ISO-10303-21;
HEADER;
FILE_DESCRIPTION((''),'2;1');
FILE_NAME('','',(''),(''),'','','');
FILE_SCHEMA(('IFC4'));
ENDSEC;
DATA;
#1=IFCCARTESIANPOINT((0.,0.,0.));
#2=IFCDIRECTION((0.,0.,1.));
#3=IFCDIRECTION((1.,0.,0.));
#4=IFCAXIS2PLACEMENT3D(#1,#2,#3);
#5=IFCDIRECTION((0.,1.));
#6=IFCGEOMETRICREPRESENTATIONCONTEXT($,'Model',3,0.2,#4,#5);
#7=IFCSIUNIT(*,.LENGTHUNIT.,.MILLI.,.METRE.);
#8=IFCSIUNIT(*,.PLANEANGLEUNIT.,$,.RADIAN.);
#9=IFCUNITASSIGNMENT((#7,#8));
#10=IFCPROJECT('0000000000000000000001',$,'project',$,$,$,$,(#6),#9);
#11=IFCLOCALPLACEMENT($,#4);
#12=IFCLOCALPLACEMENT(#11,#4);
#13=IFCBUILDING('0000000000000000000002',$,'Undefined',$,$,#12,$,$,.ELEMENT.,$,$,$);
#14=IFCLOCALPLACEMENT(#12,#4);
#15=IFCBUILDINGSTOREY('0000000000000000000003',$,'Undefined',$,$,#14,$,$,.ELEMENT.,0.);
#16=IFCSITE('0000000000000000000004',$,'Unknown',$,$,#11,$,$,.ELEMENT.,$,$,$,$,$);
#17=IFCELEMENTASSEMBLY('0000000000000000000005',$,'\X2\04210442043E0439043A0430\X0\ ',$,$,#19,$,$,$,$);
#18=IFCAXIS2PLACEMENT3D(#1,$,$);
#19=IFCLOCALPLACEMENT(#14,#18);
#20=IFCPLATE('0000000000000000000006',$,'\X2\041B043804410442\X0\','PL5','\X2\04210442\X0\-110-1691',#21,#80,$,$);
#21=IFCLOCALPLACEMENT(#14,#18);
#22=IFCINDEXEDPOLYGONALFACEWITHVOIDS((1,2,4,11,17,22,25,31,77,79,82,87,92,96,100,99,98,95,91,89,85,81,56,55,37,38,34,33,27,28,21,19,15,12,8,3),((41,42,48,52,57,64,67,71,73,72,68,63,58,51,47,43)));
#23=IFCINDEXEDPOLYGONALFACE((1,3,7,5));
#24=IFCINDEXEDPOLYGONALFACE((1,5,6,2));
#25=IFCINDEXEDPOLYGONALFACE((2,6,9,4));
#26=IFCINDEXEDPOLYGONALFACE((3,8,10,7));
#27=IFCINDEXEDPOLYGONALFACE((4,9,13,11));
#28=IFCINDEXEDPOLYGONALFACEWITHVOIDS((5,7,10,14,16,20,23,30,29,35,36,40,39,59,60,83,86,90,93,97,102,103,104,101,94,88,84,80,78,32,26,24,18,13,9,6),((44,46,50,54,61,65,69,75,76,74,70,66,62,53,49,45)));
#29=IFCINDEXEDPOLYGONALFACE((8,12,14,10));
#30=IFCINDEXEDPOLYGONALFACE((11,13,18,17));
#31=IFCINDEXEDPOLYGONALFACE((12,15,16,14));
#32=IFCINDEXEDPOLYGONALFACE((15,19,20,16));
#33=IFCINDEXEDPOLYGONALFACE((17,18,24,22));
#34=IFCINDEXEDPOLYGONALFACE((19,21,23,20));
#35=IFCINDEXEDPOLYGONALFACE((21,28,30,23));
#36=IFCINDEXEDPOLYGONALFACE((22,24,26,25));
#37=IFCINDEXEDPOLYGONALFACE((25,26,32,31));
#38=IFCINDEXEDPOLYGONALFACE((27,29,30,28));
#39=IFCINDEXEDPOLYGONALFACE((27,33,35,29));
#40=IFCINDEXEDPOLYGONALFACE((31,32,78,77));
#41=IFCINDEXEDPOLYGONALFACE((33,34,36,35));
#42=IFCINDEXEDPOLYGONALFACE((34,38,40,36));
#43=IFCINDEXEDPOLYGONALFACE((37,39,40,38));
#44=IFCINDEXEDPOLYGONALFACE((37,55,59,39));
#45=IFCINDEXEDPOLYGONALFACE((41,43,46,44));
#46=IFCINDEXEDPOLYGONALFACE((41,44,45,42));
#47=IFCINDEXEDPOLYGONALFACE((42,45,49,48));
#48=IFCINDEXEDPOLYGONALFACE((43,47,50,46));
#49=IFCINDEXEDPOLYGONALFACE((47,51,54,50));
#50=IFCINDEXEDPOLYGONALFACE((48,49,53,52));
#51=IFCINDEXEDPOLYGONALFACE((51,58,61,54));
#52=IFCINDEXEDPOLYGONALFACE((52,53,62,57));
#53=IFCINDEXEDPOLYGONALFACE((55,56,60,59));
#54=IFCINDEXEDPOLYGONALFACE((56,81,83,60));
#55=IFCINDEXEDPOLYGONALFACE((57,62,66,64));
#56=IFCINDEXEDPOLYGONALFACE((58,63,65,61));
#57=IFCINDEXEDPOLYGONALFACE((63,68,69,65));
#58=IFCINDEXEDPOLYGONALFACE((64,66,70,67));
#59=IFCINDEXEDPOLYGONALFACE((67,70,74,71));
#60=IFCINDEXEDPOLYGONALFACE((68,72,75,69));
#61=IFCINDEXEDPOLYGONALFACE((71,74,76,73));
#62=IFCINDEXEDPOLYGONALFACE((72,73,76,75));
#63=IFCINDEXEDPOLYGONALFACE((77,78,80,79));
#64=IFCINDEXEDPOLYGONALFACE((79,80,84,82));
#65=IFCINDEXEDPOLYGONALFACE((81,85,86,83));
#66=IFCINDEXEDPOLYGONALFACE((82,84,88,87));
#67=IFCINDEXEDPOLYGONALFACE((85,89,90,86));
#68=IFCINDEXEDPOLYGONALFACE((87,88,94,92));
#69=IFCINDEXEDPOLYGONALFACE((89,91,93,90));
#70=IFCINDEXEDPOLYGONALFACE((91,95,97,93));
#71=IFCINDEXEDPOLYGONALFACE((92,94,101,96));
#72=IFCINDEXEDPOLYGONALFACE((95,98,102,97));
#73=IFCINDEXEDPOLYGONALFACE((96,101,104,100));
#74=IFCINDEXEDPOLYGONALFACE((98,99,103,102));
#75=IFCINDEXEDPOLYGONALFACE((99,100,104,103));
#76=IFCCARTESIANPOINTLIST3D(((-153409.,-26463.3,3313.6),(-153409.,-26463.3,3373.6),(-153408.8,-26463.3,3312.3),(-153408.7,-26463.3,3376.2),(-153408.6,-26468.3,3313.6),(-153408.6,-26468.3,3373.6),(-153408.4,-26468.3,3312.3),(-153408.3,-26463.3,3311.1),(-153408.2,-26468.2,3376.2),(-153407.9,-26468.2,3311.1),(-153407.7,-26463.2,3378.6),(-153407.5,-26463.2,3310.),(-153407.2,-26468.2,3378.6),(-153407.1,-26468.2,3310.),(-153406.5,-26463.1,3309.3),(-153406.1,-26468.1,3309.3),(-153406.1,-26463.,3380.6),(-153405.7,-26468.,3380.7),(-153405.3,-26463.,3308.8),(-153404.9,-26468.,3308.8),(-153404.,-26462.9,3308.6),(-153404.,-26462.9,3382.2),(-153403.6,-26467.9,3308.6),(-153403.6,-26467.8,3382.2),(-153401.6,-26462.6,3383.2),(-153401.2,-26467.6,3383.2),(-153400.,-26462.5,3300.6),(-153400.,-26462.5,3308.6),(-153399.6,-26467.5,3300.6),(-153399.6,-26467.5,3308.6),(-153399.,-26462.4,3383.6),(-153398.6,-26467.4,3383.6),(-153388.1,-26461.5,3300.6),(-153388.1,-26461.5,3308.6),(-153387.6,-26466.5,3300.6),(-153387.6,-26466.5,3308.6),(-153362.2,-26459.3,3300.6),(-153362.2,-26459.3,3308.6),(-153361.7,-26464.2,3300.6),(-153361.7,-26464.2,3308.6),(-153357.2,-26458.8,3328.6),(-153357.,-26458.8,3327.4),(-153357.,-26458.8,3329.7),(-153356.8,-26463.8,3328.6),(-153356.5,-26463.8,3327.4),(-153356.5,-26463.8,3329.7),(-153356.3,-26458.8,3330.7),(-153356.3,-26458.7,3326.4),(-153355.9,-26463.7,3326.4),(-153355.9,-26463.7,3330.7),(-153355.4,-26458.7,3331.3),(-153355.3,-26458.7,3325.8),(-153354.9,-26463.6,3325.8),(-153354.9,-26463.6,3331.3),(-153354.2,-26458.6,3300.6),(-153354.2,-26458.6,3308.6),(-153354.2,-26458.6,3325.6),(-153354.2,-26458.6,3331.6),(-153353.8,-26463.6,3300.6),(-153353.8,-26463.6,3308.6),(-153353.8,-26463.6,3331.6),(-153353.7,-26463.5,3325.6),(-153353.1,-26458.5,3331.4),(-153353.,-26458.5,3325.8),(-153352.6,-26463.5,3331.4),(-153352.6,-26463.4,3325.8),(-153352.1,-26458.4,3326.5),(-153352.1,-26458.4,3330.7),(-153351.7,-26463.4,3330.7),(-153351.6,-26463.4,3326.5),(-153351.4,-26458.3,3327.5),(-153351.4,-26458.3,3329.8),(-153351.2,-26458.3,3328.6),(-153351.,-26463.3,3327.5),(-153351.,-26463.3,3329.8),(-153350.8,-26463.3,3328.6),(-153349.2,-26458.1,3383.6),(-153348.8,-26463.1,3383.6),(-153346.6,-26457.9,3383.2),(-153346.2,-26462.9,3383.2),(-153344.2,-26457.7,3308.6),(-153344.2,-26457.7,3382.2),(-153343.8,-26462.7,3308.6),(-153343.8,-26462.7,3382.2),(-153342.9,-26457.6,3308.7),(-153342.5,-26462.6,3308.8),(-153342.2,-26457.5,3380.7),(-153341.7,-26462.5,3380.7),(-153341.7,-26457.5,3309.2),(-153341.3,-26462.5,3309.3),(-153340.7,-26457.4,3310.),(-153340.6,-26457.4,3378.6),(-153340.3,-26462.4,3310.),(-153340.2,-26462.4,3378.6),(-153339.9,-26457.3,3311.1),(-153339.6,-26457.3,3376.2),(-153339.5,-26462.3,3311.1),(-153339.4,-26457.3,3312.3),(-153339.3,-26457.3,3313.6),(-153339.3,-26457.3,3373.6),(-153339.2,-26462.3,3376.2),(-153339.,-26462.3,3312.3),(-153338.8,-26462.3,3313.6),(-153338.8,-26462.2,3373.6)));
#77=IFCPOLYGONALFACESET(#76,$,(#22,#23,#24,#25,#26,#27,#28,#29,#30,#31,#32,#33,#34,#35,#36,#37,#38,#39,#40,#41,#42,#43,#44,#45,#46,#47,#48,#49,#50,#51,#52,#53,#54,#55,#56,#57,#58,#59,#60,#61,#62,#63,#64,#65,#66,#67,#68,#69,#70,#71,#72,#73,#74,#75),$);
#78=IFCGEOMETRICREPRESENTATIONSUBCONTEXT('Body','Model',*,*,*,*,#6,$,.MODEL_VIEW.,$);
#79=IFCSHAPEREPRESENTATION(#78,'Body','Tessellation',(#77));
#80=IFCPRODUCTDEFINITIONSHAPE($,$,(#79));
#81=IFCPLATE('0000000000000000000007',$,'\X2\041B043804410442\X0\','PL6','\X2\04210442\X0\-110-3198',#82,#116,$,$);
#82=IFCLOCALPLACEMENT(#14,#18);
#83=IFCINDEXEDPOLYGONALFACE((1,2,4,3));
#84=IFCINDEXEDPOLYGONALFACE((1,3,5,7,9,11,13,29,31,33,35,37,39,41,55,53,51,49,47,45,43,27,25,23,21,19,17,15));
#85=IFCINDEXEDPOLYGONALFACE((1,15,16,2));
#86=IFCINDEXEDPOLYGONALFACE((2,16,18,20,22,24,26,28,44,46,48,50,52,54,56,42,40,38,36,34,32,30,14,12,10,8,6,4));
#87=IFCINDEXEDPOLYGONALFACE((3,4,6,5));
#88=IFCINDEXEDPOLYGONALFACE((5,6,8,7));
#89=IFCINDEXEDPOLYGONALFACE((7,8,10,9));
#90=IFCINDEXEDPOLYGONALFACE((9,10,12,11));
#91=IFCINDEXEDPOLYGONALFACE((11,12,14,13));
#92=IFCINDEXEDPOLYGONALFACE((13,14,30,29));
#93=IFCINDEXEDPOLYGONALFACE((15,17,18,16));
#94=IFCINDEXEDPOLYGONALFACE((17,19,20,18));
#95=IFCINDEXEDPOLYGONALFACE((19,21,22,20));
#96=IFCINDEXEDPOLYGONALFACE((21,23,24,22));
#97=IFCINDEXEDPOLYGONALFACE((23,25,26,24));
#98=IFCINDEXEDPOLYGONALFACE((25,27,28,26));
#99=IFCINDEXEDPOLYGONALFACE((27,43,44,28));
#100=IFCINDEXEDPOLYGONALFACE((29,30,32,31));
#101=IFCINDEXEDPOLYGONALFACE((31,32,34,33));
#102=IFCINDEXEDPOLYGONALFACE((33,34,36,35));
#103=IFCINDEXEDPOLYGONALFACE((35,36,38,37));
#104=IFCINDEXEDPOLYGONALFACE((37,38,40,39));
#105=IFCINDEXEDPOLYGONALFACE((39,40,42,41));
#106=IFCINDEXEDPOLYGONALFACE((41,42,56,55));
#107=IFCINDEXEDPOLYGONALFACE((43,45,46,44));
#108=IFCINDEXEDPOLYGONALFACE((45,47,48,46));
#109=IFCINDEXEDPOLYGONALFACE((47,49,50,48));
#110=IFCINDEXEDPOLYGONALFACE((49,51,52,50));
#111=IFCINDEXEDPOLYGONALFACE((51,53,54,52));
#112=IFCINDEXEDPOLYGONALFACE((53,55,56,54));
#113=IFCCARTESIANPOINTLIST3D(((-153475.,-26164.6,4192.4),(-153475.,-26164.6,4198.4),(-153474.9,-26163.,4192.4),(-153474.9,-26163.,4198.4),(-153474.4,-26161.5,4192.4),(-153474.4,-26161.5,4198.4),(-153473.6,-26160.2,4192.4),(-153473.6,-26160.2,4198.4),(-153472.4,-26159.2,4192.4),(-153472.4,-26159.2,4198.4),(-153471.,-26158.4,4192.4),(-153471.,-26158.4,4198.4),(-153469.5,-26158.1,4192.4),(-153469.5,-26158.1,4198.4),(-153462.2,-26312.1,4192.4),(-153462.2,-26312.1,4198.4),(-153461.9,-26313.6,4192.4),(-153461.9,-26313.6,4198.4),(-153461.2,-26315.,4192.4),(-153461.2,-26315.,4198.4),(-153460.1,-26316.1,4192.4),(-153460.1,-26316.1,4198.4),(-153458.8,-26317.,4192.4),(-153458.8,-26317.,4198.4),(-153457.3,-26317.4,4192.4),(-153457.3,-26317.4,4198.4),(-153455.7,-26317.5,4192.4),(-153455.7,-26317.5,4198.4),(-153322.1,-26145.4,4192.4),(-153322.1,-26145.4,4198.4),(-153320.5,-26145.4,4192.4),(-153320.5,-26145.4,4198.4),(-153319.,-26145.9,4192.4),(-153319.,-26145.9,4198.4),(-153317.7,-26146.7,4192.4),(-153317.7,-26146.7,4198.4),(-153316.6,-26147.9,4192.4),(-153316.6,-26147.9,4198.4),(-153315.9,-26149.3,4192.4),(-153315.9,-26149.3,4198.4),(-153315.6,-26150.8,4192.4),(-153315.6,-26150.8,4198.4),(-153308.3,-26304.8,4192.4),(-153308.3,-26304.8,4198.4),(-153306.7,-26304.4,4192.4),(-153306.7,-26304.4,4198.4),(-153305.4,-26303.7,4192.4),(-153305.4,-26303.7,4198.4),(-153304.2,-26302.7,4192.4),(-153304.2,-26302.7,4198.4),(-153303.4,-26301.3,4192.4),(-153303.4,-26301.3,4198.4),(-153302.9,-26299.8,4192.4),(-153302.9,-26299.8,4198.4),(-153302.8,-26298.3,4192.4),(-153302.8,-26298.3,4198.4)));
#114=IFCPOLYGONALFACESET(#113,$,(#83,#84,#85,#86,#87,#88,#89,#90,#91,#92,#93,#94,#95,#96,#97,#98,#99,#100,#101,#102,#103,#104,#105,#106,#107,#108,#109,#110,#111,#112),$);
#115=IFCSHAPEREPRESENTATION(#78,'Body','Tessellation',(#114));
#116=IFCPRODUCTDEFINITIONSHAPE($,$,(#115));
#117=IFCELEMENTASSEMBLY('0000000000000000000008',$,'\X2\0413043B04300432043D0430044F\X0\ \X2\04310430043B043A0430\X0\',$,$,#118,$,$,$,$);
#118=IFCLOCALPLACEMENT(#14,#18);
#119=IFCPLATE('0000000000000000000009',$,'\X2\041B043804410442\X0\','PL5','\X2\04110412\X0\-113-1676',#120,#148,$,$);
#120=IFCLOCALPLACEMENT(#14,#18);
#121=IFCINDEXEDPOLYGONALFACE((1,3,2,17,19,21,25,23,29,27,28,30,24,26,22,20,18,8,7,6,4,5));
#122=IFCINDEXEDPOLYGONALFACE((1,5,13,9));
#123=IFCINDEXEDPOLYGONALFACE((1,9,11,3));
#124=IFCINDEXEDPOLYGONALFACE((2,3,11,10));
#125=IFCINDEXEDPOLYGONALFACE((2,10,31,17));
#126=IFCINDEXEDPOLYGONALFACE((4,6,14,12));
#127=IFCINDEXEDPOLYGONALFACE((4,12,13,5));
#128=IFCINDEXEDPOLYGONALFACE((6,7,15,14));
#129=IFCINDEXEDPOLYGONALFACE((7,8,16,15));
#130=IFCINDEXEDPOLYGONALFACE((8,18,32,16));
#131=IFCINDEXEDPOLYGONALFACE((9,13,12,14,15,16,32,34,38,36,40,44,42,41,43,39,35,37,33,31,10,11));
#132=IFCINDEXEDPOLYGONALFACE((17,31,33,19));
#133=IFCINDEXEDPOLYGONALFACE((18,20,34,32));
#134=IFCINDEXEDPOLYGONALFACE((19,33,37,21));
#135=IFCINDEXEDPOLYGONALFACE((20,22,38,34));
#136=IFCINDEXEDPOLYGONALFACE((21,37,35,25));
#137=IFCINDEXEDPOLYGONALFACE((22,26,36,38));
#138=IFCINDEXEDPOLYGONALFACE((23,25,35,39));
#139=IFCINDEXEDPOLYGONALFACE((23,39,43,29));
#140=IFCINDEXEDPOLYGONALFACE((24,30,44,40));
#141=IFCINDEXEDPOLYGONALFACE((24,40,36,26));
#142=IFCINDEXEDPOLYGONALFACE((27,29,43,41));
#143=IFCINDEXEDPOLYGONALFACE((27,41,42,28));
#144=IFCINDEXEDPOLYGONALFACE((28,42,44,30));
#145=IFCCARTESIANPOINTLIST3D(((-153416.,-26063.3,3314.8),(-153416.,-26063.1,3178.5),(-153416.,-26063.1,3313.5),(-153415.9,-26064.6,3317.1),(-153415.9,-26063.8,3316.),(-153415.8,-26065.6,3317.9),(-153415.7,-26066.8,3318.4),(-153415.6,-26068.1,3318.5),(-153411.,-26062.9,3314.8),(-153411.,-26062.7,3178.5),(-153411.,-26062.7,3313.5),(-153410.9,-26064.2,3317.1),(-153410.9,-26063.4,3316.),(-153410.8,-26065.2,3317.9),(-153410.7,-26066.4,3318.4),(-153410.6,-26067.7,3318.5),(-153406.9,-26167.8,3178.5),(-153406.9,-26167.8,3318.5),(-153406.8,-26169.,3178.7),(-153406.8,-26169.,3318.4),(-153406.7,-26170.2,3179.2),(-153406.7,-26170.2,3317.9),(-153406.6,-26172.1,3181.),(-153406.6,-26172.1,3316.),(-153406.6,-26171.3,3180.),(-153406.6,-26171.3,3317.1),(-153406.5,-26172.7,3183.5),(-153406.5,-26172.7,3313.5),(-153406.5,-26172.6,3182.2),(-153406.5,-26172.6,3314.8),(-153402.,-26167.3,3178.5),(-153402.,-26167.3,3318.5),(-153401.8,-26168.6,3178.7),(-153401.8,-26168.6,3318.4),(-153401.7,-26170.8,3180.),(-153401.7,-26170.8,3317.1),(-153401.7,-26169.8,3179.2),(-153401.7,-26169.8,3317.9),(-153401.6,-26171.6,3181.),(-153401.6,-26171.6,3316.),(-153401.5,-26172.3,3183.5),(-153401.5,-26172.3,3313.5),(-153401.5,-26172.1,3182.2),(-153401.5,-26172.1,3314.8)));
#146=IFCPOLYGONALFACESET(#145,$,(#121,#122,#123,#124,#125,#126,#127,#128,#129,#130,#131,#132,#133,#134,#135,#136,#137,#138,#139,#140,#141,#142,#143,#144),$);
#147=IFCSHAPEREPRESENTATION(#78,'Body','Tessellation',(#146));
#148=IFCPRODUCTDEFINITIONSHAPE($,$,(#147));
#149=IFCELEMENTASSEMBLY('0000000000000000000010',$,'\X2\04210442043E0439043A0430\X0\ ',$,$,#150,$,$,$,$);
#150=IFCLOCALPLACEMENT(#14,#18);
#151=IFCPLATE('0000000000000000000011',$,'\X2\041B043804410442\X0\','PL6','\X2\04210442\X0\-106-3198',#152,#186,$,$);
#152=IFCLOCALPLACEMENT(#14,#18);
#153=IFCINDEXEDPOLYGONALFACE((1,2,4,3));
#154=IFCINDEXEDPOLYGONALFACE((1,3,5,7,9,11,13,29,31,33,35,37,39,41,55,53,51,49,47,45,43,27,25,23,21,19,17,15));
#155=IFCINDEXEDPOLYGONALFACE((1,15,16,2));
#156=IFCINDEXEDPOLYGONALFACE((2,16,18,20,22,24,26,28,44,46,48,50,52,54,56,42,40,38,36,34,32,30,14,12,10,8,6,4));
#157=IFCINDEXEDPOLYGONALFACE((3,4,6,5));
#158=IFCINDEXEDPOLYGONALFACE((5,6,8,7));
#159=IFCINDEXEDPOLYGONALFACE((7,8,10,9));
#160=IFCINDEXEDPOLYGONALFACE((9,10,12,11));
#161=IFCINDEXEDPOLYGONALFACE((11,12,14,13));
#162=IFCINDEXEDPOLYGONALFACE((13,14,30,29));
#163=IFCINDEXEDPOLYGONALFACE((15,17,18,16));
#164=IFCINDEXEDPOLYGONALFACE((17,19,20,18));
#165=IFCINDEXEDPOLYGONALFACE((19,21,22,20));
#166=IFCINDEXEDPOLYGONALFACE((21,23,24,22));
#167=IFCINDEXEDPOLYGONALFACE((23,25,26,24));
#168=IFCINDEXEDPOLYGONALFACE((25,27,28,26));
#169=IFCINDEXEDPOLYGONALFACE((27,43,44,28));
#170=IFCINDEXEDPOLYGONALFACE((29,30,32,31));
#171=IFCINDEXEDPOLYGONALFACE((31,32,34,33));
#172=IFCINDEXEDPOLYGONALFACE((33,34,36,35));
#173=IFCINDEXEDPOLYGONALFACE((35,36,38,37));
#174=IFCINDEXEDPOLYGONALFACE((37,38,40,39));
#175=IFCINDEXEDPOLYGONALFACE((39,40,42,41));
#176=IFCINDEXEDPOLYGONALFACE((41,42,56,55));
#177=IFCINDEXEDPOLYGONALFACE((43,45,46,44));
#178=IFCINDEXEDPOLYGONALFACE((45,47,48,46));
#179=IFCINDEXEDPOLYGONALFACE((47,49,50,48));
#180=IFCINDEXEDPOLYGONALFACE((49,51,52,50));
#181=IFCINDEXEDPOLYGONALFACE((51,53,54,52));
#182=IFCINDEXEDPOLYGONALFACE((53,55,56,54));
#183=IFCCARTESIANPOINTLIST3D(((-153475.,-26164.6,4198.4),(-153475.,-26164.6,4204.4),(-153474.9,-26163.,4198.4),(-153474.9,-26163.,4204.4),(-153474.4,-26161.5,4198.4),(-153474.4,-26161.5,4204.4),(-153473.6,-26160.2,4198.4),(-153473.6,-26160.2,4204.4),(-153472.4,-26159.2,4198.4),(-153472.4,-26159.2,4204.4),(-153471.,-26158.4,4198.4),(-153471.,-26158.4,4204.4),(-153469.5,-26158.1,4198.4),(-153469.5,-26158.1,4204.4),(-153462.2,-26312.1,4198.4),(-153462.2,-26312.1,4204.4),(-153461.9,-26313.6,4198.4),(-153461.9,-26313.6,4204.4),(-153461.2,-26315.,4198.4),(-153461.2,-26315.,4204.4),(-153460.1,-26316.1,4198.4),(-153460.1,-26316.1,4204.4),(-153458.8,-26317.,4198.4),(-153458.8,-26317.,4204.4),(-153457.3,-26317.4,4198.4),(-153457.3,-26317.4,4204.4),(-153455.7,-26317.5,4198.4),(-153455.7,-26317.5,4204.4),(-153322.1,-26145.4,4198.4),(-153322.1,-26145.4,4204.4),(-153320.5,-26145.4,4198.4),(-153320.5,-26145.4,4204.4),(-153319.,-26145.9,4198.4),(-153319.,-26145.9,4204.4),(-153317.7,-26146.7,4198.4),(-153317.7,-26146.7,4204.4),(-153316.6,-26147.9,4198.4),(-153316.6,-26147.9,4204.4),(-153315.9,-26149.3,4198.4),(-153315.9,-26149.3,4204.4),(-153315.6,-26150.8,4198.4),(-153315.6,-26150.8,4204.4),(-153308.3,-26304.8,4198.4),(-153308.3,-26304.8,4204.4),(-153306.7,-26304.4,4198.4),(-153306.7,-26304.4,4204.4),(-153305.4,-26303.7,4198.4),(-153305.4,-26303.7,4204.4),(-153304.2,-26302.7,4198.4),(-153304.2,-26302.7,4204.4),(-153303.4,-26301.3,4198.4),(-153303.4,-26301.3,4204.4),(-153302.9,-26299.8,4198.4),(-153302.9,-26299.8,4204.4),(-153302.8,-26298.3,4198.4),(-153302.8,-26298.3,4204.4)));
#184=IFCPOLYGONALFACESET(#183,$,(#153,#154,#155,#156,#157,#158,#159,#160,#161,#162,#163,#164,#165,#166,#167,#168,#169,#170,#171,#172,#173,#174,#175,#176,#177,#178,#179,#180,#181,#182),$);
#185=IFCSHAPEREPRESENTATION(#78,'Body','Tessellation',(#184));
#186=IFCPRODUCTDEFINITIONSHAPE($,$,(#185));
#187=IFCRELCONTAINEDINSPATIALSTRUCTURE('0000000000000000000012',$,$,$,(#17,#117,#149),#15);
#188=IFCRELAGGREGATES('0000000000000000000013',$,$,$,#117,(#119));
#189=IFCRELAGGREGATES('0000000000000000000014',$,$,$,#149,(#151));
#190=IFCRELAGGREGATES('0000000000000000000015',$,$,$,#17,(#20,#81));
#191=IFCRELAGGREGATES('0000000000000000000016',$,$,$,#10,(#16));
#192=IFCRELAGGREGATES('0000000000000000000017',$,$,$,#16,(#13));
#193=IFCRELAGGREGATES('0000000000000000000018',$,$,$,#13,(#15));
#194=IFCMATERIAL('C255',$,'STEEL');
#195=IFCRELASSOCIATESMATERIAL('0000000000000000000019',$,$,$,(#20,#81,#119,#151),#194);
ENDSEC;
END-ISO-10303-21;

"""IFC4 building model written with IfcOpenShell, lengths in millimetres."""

from ifc_helpers import new_model, si_unit, direction, frame, origin_with_axes, place, context, subcontext, project, spatial, line, arc, indexed_curve, outline, extrude, material, element, aggregate, save


model = new_model("IFC4")

# Units and contexts
model_context = context("Model", 3, precision=0.2, world=origin_with_axes(), true_north=direction((0.0, 1.0)))
body_context = subcontext(model_context, "Body", "Model", "MODEL_VIEW")
ifc_project = project(units=[si_unit("LENGTHUNIT", "METRE", prefix="MILLI"), si_unit("PLANEANGLEUNIT", "RADIAN")], contexts=[model_context])

# Site, building, storey
site_placement = place(None, origin_with_axes())
site = spatial("IfcSite", under=ifc_project, at=site_placement, Name="Unknown", CompositionType="ELEMENT")
building_placement = place(site_placement, origin_with_axes())
building = spatial("IfcBuilding", under=site, at=building_placement, Name="Undefined", CompositionType="ELEMENT")
storey_placement = place(building_placement, origin_with_axes())
storey = spatial("IfcBuildingStorey", under=building, at=storey_placement, Name="Undefined", CompositionType="ELEMENT", Elevation=0.0)

# Element assembly, plates, voiding feature
assembly_1_placement = place(storey_placement, frame((-153388.9, -26231.4, 131.5), z_axis=(-0.086114, 0.996285, 0.0), x_axis=(0.0, 0.0, 1.0)))
assembly_1 = element("IfcElementAssembly", 1, at=assembly_1_placement, inside=storey, Name="Стойка ")
ifc_material_1 = material(Name="C255", Category="STEEL")
plate_1_placement = place(assembly_1_placement, frame((3252.1, 30.0, -231.8), z_axis=(0.000357, 0.0, -1.0), x_axis=(-0.00003, -1.0, 0.0)))
plate_1 = element("IfcPlate", 2, at=plate_1_placement, material=ifc_material_1, Name="Лист", Description="PL5", ObjectType="Ст-110-1691", context=body_context, shape_type="SolidModel", body=[
    extrude(outline(indexed_curve([(0.0, 10.0), (2.9, 2.9), (10.0, 0.0), (60.0, 0.0), (67.1, 2.9), (70.0, 10.0), (70.0, 70.0), (68.5, 73.5), (65.0, 75.0), (61.0, 75.0), (61.0, 83.0), (49.0, 83.0), (49.0, 75.0), (23.0, 75.0), (23.0, 83.0), (15.0, 83.0), (15.0, 75.0), (5.0, 75.0), (1.5, 73.5), (0.0, 70.0)], segments=[arc(1, 2, 3), line(3, 4), arc(4, 5, 6), line(6, 7), arc(7, 8, 9), line(9, 10, 11, 12, 13, 14, 15, 16, 17, 18), arc(18, 19, 20), line(20, 1)])), frame((0.0, 0.0, 2.5), z_axis=(0.0, 0.0, 1.0), x_axis=(1.0, 0.0, 0.0)), (0.0, 0.0, -1.0), 5.0),
])
voiding_feature_1_placement = place(plate_1_placement, frame((15.0, 55.0, 10.0), z_axis=(0.007997, -0.999968, -0.000026), x_axis=(0.0, 0.000026, -1.0)))
element("IfcVoidingFeature", 3, at=voiding_feature_1_placement, cuts=plate_1, Name="Балка", ObjectType="(?)", PredefinedType="HOLE", context=body_context, shape_type="SolidModel", body=[
    extrude(outline(indexed_curve([(3.0, 0.0), (2.8, 1.1), (2.1, 2.1), (1.1, 2.8), (0.0, 3.0), (-1.1, 2.8), (-2.1, 2.1), (-2.8, 1.1), (-3.0, 0.0), (-2.8, -1.1), (-2.1, -2.1), (-1.1, -2.8), (0.0, -3.0), (1.1, -2.8), (2.1, -2.1), (2.8, -1.1)], segments=[line(1, 2, 3, 4, 5, 6, 7, 8, 9, 10, 11, 12, 13, 14, 15, 16, 1)])), frame((0.0, 0.0, 0.0), z_axis=(-1.0, 0.0, 0.0), x_axis=(0.0, 0.0, 1.0)), (0.0, 0.0, -1.0), 20.0),
])
plate_2_placement = place(assembly_1_placement, frame((4063.8, 80.0, -80.0), z_axis=(1.0, 0.0, 0.0), x_axis=(0.0, 0.0, 1.0)))
plate_2 = element("IfcPlate", 4, at=plate_2_placement, material=ifc_material_1, Name="Лист", Description="PL6", ObjectType="Ст-110-3198", context=body_context, shape_type="SolidModel", body=[
    extrude(outline(indexed_curve([(0.0, 6.0), (1.8, 1.8), (6.0, 0.0), (154.0, 0.0), (158.2, 1.8), (160.0, 6.0), (160.0, 154.0), (158.2, 158.2), (154.0, 160.0), (6.0, 160.0), (1.8, 158.2), (0.0, 154.0)], segments=[arc(1, 2, 3), line(3, 4), arc(4, 5, 6), line(6, 7), arc(7, 8, 9), line(9, 10), arc(10, 11, 12), line(12, 1)])), frame((0.0, 0.0, 3.0), z_axis=(0.0, 0.0, 1.0), x_axis=(1.0, 0.0, 0.0)), (0.0, 0.0, -1.0), 6.0),
])

# Element assemblies, plates
assembly_2_placement = place(storey_placement, frame((-153409.2, -26112.7, 3248.5), z_axis=(-0.996285, -0.086114, -0.000024), x_axis=(-0.086114, 0.996285, 0.0)))
assembly_2 = element("IfcElementAssembly", 5, at=assembly_2_placement, inside=storey, Name="Главная балка")
plate_3_placement = place(assembly_2_placement, frame((-60.0, -70.0, 0.0), z_axis=(0.0, 0.0, -1.0), x_axis=(0.0, 1.0, 0.0)))
plate_3 = element("IfcPlate", 6, at=plate_3_placement, material=ifc_material_1, Name="Лист", Description="PL5", ObjectType="БВ-113-1676", context=body_context, shape_type="SolidModel", body=[
    extrude(outline(indexed_curve([(0.0, 5.0), (1.5, 1.5), (5.0, 0.0), (135.0, 0.0), (138.5, 1.5), (140.0, 5.0), (140.0, 110.0), (5.0, 110.0), (1.5, 108.5), (0.0, 105.0)], segments=[arc(1, 2, 3), line(3, 4), arc(4, 5, 6), line(6, 7, 8), arc(8, 9, 10), line(10, 1)])), frame((0.0, 0.0, 2.5), z_axis=(0.0, 0.0, 1.0), x_axis=(1.0, 0.0, 0.0)), (0.0, 0.0, -1.0), 5.0),
])
aggregate(assembly_2, [plate_3])
assembly_3_placement = place(storey_placement, frame((-153388.9, -26231.4, 4198.4), z_axis=(-0.086114, 0.996285, 0.0), x_axis=(0.0, 0.0, 1.0)))
assembly_3 = element("IfcElementAssembly", 7, at=assembly_3_placement, inside=storey, Name="Стойка ")
plate_4_placement = place(assembly_3_placement, frame((3.0, 80.0, -80.0), z_axis=(1.0, 0.0, 0.0), x_axis=(0.0, 0.0, 1.0)))
plate_4 = element("IfcPlate", 8, at=plate_4_placement, material=ifc_material_1, Name="Лист", Description="PL6", ObjectType="Ст-106-3198", context=body_context, shape_type="SolidModel", body=[
    extrude(outline(indexed_curve([(0.0, 6.0), (1.8, 1.8), (6.0, 0.0), (154.0, 0.0), (158.2, 1.8), (160.0, 6.0), (160.0, 154.0), (158.2, 158.2), (154.0, 160.0), (6.0, 160.0), (1.8, 158.2), (0.0, 154.0)], segments=[arc(1, 2, 3), line(3, 4), arc(4, 5, 6), line(6, 7), arc(7, 8, 9), line(9, 10), arc(10, 11, 12), line(12, 1)])), frame((0.0, 0.0, 3.0), z_axis=(0.0, 0.0, 1.0), x_axis=(1.0, 0.0, 0.0)), (0.0, 0.0, -1.0), 6.0),
])
aggregate(assembly_3, [plate_4])

aggregate(assembly_1, [plate_1, plate_2])

save(model, "model.ifc")
